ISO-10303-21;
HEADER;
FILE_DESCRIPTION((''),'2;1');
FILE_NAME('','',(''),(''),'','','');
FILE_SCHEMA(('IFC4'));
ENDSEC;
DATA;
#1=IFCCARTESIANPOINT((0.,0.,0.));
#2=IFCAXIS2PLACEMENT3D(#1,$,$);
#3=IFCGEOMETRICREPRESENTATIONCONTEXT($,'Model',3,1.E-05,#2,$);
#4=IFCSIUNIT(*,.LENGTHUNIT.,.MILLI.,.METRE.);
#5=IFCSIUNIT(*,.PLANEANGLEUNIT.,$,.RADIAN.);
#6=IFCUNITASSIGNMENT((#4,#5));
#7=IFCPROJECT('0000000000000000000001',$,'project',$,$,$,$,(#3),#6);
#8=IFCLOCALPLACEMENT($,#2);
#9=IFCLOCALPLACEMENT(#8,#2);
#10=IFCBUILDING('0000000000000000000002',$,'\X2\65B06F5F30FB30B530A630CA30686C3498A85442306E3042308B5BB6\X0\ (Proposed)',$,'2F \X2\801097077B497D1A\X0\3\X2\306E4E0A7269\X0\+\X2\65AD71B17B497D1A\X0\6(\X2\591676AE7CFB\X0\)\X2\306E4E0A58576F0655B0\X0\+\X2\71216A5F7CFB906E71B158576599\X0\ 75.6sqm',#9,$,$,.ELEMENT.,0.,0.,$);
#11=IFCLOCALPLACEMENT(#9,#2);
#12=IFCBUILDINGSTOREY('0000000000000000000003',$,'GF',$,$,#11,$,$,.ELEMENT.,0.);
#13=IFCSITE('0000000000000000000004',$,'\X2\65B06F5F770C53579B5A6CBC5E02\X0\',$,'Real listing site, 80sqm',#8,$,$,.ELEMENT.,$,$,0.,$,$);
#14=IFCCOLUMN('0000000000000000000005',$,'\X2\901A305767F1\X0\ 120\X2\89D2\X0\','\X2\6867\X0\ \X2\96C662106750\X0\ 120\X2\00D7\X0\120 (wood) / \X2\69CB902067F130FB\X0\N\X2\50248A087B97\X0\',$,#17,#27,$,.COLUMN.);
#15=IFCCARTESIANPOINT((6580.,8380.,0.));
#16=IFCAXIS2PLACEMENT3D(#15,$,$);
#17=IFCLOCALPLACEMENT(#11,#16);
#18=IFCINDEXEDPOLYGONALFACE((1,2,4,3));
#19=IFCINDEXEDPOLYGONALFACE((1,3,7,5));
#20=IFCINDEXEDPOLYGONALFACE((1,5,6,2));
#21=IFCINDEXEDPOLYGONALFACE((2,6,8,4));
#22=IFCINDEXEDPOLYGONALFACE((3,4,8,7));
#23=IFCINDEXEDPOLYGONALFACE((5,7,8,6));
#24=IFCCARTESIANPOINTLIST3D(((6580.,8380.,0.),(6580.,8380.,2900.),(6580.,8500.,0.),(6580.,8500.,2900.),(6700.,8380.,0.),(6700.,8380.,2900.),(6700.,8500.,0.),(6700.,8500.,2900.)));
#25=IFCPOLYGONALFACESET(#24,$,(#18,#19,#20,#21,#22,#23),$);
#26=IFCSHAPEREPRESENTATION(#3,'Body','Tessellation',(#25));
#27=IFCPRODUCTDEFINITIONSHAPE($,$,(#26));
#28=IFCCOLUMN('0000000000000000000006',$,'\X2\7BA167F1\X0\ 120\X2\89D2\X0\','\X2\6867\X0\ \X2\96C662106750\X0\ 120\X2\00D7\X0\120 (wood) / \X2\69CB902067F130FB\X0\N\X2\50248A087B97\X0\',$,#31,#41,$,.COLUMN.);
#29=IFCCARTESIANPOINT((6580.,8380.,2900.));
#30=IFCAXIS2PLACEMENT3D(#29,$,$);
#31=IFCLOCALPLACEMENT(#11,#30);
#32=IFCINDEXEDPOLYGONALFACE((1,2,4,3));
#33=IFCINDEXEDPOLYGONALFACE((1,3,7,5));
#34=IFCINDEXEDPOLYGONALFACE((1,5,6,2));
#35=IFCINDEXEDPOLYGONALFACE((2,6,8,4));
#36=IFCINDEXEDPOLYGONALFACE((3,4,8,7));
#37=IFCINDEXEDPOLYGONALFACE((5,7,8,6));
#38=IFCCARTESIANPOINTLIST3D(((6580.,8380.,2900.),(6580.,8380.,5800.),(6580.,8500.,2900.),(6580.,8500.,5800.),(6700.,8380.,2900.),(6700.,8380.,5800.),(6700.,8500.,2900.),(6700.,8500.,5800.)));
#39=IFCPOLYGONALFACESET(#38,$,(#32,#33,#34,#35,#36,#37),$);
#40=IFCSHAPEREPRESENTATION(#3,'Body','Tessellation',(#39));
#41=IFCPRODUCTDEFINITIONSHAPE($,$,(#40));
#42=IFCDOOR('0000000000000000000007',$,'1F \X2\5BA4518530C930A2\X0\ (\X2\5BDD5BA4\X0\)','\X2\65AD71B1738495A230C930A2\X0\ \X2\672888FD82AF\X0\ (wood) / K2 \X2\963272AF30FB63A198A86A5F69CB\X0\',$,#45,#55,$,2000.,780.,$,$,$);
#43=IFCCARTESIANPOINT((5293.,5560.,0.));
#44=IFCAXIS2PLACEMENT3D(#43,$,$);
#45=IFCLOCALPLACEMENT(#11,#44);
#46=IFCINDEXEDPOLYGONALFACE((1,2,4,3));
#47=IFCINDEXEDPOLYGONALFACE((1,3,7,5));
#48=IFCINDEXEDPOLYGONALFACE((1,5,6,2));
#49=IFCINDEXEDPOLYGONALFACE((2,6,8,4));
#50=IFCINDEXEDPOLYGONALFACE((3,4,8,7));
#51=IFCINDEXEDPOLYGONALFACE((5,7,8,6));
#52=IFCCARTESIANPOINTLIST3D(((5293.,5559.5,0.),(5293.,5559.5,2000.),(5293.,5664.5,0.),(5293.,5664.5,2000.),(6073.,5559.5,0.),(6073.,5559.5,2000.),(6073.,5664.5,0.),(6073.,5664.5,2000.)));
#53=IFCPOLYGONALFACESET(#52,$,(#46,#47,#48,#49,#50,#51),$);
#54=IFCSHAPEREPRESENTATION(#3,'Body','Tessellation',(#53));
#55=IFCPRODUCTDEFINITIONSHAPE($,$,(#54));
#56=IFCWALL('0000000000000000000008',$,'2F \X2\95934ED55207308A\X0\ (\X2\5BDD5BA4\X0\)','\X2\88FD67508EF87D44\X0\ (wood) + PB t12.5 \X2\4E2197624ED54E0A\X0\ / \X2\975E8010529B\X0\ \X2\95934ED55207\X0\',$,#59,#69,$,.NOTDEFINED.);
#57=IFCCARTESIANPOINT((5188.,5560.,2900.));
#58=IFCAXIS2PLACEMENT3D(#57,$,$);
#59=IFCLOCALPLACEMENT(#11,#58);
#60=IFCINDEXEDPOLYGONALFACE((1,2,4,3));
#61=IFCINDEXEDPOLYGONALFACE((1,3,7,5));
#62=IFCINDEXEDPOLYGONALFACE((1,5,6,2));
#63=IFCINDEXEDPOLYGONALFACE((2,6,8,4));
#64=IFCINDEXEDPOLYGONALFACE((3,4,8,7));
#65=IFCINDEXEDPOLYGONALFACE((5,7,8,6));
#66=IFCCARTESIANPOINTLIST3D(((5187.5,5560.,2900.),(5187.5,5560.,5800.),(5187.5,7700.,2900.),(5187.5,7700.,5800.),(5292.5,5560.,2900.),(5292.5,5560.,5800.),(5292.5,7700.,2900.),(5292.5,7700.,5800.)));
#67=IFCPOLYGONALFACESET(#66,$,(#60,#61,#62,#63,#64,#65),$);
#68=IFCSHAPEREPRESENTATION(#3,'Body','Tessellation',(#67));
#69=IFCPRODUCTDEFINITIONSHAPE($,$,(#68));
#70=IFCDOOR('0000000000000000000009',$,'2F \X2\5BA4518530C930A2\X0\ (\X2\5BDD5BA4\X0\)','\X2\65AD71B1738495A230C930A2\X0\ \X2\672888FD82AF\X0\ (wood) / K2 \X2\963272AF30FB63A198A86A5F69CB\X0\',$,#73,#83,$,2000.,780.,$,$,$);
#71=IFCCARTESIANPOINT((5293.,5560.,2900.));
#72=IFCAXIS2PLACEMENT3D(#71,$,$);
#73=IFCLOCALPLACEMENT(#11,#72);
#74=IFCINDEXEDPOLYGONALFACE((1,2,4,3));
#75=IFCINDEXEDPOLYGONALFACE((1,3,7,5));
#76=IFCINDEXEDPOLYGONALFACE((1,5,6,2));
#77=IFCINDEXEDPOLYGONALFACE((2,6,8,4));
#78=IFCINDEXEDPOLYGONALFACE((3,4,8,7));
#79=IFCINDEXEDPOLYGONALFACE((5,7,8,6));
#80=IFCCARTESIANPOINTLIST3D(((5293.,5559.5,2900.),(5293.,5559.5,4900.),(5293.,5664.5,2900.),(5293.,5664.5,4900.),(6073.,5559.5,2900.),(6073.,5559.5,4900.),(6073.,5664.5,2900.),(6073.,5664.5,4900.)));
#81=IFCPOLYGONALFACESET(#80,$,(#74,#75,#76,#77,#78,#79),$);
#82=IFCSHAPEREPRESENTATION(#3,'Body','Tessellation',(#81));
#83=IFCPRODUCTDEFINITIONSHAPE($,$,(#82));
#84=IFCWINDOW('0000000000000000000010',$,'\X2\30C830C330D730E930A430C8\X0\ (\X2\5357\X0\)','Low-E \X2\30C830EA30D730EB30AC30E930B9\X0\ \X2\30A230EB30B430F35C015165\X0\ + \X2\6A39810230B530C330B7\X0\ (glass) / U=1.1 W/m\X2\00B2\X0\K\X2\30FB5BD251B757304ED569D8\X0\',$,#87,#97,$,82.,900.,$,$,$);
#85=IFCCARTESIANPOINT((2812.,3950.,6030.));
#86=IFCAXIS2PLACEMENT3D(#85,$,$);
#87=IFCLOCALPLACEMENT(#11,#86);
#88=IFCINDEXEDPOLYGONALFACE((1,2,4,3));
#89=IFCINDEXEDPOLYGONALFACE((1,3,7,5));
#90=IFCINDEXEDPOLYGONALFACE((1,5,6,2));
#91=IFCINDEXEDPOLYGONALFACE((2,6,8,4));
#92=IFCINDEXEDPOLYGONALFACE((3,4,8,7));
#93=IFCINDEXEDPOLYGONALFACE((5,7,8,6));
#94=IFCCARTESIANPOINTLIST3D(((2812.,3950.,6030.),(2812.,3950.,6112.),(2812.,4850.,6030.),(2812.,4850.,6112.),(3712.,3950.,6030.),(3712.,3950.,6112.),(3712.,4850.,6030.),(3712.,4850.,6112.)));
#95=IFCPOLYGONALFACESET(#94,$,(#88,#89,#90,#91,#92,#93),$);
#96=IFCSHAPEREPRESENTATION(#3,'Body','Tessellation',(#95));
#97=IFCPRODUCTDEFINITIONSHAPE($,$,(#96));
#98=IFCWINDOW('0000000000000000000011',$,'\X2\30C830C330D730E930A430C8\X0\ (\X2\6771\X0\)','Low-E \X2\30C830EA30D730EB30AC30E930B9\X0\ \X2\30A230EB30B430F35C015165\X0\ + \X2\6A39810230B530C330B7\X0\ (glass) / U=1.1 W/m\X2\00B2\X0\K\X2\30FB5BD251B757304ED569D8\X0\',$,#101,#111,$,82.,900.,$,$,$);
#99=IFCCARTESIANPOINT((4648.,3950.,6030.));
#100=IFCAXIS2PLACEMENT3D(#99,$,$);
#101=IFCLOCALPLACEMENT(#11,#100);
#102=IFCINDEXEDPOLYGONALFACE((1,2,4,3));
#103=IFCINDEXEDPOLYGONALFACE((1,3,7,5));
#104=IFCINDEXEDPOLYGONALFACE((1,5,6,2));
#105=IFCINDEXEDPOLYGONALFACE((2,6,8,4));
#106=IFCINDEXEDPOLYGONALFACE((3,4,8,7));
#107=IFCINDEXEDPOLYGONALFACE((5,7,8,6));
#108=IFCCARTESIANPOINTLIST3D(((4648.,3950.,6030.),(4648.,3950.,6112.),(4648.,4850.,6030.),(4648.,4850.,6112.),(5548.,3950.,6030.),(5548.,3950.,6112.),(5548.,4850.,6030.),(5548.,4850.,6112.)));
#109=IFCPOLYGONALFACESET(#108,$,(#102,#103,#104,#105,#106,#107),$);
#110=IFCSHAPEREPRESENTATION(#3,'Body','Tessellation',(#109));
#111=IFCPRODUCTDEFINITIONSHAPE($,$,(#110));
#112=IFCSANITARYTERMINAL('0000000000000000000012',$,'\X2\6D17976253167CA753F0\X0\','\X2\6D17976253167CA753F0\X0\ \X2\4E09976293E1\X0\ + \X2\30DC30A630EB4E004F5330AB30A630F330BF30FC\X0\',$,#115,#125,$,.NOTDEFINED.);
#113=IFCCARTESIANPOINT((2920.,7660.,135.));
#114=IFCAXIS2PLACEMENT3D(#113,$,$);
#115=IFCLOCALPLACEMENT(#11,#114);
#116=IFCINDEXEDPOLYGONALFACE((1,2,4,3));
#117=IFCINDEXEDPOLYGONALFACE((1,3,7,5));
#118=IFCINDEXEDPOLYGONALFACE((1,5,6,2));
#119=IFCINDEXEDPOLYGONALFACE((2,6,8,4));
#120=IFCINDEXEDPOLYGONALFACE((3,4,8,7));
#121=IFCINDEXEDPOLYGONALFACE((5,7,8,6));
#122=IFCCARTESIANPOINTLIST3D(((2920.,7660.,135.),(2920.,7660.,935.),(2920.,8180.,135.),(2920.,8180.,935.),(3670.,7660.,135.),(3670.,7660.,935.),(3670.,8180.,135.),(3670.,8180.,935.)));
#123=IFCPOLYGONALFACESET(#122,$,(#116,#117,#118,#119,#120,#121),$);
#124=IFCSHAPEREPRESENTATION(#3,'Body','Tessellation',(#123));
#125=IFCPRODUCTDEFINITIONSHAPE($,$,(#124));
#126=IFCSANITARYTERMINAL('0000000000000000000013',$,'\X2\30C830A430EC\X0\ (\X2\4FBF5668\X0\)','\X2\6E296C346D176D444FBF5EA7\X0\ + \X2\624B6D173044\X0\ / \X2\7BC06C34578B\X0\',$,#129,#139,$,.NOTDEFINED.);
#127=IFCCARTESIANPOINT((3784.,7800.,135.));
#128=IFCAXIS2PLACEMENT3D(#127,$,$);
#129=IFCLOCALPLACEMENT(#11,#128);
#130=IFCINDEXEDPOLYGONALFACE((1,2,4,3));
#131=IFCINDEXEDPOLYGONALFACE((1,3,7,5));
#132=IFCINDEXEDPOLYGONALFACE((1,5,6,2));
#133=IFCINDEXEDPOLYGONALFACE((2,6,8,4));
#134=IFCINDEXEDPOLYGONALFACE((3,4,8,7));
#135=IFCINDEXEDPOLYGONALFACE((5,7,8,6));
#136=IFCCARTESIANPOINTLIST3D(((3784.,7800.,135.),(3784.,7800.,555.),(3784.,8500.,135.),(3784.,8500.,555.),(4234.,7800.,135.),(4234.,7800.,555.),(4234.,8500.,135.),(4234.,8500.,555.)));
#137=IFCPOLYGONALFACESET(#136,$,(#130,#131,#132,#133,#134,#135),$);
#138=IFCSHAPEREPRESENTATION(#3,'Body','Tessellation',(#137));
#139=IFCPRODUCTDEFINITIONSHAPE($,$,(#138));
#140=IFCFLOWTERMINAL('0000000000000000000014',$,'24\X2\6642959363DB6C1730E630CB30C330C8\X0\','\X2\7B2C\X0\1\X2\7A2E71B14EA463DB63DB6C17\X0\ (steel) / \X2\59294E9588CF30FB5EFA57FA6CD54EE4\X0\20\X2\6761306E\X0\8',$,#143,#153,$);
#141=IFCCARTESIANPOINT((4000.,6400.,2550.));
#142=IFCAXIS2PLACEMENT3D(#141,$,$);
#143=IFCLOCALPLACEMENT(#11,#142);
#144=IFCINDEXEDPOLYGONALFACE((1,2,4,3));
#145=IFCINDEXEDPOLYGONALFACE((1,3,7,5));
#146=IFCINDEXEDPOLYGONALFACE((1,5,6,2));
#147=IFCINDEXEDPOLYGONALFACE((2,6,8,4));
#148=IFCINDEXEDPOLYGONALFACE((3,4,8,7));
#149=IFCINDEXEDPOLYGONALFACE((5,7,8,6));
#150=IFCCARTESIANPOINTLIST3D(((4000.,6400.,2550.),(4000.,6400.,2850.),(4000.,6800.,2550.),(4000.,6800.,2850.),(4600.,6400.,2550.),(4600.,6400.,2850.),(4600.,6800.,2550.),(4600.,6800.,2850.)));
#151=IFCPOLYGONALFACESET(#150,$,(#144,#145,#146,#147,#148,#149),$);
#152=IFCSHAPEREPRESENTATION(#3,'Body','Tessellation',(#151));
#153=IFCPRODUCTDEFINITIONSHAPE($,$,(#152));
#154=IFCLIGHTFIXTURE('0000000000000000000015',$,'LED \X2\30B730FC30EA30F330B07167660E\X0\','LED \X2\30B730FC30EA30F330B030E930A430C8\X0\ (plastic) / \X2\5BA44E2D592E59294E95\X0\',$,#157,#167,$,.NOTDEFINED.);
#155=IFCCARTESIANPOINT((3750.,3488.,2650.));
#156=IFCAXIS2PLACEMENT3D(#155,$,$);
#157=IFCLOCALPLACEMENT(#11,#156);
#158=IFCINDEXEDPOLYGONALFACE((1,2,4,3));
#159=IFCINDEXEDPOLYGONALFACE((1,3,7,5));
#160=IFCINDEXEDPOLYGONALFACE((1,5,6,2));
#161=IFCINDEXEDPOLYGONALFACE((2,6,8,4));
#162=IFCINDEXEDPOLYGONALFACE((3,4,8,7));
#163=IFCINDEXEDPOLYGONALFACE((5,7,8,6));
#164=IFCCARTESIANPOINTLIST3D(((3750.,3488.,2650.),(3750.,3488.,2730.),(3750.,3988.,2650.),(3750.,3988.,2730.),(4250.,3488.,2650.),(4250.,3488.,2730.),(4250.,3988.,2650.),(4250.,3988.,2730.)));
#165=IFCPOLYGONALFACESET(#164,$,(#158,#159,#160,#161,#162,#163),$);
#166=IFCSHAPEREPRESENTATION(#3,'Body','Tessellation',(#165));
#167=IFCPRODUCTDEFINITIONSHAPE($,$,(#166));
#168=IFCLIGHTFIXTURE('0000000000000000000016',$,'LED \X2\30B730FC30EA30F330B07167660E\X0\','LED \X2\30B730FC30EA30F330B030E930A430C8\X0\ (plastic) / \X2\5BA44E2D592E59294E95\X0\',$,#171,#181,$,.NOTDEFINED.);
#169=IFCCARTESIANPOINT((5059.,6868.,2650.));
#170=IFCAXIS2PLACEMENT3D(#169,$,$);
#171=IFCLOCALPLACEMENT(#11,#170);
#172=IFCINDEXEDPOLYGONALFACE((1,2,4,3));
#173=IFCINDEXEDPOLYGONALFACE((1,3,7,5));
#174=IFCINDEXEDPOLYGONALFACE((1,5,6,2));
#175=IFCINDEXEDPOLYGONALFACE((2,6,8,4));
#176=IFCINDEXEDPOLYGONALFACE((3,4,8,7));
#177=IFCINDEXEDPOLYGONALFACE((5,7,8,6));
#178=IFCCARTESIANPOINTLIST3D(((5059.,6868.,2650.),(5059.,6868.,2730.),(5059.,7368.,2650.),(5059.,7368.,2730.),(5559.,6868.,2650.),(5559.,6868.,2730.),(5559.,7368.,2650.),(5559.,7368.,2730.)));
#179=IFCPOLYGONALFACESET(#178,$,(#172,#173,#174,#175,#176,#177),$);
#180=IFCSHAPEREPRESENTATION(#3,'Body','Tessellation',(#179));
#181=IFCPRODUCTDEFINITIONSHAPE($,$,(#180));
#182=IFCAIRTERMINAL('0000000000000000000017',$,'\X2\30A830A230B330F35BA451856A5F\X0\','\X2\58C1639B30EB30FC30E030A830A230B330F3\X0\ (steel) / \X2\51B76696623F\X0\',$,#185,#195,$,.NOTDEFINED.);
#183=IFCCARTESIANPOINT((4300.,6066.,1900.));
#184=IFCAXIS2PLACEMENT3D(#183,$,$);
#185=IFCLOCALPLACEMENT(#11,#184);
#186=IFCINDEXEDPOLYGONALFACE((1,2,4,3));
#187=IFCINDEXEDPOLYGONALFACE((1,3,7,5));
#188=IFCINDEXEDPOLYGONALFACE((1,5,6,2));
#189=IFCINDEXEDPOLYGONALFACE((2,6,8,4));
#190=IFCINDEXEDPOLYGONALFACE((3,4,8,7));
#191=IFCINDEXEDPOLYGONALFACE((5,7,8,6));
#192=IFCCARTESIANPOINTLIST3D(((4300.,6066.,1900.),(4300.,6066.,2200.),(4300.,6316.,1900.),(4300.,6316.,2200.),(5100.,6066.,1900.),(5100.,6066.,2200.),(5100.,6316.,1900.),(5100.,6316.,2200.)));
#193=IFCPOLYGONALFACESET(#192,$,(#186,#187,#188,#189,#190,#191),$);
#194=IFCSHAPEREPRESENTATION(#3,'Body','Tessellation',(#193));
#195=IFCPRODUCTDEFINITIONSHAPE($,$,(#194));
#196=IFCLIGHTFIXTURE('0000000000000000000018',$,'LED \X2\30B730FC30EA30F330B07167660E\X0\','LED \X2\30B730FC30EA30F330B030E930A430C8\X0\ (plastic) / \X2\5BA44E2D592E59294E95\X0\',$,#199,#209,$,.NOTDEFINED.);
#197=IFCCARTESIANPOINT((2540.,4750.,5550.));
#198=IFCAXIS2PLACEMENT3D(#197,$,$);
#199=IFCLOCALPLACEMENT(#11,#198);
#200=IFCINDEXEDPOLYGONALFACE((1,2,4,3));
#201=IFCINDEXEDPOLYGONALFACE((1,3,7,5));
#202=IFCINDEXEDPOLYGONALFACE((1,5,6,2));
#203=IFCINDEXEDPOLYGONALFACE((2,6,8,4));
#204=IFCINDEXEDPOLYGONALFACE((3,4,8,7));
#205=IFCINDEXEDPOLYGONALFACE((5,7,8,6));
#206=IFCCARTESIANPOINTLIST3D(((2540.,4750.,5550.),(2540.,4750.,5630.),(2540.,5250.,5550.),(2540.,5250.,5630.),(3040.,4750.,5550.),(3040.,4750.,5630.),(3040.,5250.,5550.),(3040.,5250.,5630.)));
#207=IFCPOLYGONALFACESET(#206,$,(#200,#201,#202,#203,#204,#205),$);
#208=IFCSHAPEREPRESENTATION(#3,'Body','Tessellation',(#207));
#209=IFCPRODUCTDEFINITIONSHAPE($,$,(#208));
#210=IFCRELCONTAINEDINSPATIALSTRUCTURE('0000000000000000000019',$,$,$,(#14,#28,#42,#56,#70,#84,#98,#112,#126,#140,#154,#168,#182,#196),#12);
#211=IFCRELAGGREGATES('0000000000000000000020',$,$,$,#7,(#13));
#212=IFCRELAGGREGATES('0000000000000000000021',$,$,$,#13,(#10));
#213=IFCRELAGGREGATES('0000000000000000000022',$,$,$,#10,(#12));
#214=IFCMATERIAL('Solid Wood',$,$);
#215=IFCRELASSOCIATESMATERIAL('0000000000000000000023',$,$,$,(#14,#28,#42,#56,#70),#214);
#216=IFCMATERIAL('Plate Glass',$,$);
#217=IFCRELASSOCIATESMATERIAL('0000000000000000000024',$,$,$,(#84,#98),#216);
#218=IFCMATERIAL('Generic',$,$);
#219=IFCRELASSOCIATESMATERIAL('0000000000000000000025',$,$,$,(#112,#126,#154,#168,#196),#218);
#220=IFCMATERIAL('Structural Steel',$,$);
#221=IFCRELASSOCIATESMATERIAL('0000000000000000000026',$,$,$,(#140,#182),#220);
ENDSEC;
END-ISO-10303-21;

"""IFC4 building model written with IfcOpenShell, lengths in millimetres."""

from ifc_helpers import new_model, si_unit, frame, frame_2d, origin, place, context, project, spatial, rectangle, extrude, material, element, save


model = new_model("IFC4")

# Units and contexts
model_context = context("Model", 3, precision=1e-05, world=origin())
ifc_project = project(units=[si_unit("LENGTHUNIT", "METRE", prefix="MILLI"), si_unit("PLANEANGLEUNIT", "RADIAN")], contexts=[model_context])

# Site, building, storey
site_placement = place(None, origin())
site = spatial("IfcSite", under=ifc_project, at=site_placement, Name="新潟県南魚沼市", ObjectType="Real listing site, 80sqm", CompositionType="ELEMENT", RefElevation=0.0)
building_placement = place(site_placement, origin())
building = spatial("IfcBuilding", under=site, at=building_placement, Name="新潟・サウナと水風呂のある家 (Proposed)", ObjectType="2F 耐震等級3の上物+断熱等級6(外皮系)の上塗漆喰+無機系遮熱塗料 75.6sqm", CompositionType="ELEMENT", ElevationOfRefHeight=0.0, ElevationOfTerrain=0.0)
storey_placement = place(building_placement, origin())
storey = spatial("IfcBuildingStorey", under=building, at=storey_placement, Name="GF", CompositionType="ELEMENT", Elevation=0.0)

# Columns
ifc_material_1 = material(Name="Solid Wood")
column_1_placement = place(storey_placement, frame((6580.0, 8380.0, 0.0)))
element("IfcColumn", 1, at=column_1_placement, inside=storey, material=ifc_material_1, Name="通し柱 120角", Description="桧 集成材 120×120 (wood) / 構造柱・N値計算", PredefinedType="COLUMN", context=model_context, shape_type="SweptSolid", body=[
    extrude(rectangle(XDim=120.0, YDim=120.0, at=frame_2d((60.0, 60.0))), frame((6580.0, 8380.0, 0.0)), (0.0, 0.0, 1.0), 2900.0),
])
column_2_placement = place(storey_placement, frame((6580.0, 8380.0, 2900.0)))
element("IfcColumn", 2, at=column_2_placement, inside=storey, material=ifc_material_1, Name="管柱 120角", Description="桧 集成材 120×120 (wood) / 構造柱・N値計算", PredefinedType="COLUMN", context=model_context, shape_type="SweptSolid", body=[
    extrude(rectangle(XDim=120.0, YDim=120.0, at=frame_2d((60.0, 60.0))), frame((6580.0, 8380.0, 2900.0)), (0.0, 0.0, 1.0), 2900.0),
])

# Door
door_1_placement = place(storey_placement, frame((5293.0, 5560.0, 0.0)))
element("IfcDoor", 3, at=door_1_placement, inside=storey, material=ifc_material_1, Name="1F 室内ドア (寝室)", Description="断熱玄関ドア 木製芯 (wood) / K2 防犯・採風機構", OverallHeight=2000.0, OverallWidth=780.0, context=model_context, shape_type="SweptSolid", body=[
    extrude(rectangle(XDim=780.0, YDim=105.0, at=frame_2d((390.0, 52.0))), frame((5293.0, 5560.0, 0.0)), (0.0, 0.0, 1.0), 2000.0),
])

# Wall
wall_1_placement = place(storey_placement, frame((5188.0, 5560.0, 2900.0)))
element("IfcWall", 4, at=wall_1_placement, inside=storey, material=ifc_material_1, Name="2F 間仕切り (寝室)", Description="製材軸組 (wood) + PB t12.5 両面仕上 / 非耐力 間仕切", PredefinedType="NOTDEFINED", context=model_context, shape_type="SweptSolid", body=[
    extrude(rectangle(XDim=105.0, YDim=2140.0, at=frame_2d((52.0, 1070.0))), frame((5188.0, 5560.0, 2900.0)), (0.0, 0.0, 1.0), 2900.0),
])

# Door
door_2_placement = place(storey_placement, frame((5293.0, 5560.0, 2900.0)))
element("IfcDoor", 5, at=door_2_placement, inside=storey, material=ifc_material_1, Name="2F 室内ドア (寝室)", Description="断熱玄関ドア 木製芯 (wood) / K2 防犯・採風機構", OverallHeight=2000.0, OverallWidth=780.0, context=model_context, shape_type="SweptSolid", body=[
    extrude(rectangle(XDim=780.0, YDim=105.0, at=frame_2d((390.0, 52.0))), frame((5293.0, 5560.0, 2900.0)), (0.0, 0.0, 1.0), 2000.0),
])

# Windows
ifc_material_2 = material(Name="Plate Glass")
window_1_placement = place(storey_placement, frame((2812.0, 3950.0, 6030.0)))
element("IfcWindow", 6, at=window_1_placement, inside=storey, material=ifc_material_2, Name="トップライト (南)", Description="Low-E トリプルガラス アルゴン封入 + 樹脂サッシ (glass) / U=1.1 W/m²K・寒冷地仕様", OverallHeight=82.0, OverallWidth=900.0, context=model_context, shape_type="SweptSolid", body=[
    extrude(rectangle(XDim=900.0, YDim=900.0, at=frame_2d((450.0, 450.0))), frame((2812.0, 3950.0, 6030.0)), (0.0, 0.0, 1.0), 82.0),
])
window_2_placement = place(storey_placement, frame((4648.0, 3950.0, 6030.0)))
element("IfcWindow", 7, at=window_2_placement, inside=storey, material=ifc_material_2, Name="トップライト (東)", Description="Low-E トリプルガラス アルゴン封入 + 樹脂サッシ (glass) / U=1.1 W/m²K・寒冷地仕様", OverallHeight=82.0, OverallWidth=900.0, context=model_context, shape_type="SweptSolid", body=[
    extrude(rectangle(XDim=900.0, YDim=900.0, at=frame_2d((450.0, 450.0))), frame((4648.0, 3950.0, 6030.0)), (0.0, 0.0, 1.0), 82.0),
])

# Sanitary terminals
ifc_material_3 = material(Name="Generic")
sanitary_terminal_1_placement = place(storey_placement, frame((2920.0, 7660.0, 135.0)))
element("IfcSanitaryTerminal", 8, at=sanitary_terminal_1_placement, inside=storey, material=ifc_material_3, Name="洗面化粧台", Description="洗面化粧台 三面鏡 + ボウル一体カウンター", PredefinedType="NOTDEFINED", context=model_context, shape_type="SweptSolid", body=[
    extrude(rectangle(XDim=750.0, YDim=520.0, at=frame_2d((375.0, 260.0))), frame((2920.0, 7660.0, 135.0)), (0.0, 0.0, 1.0), 800.0),
])
sanitary_terminal_2_placement = place(storey_placement, frame((3784.0, 7800.0, 135.0)))
element("IfcSanitaryTerminal", 9, at=sanitary_terminal_2_placement, inside=storey, material=ifc_material_3, Name="トイレ (便器)", Description="温水洗浄便座 + 手洗い / 節水型", PredefinedType="NOTDEFINED", context=model_context, shape_type="SweptSolid", body=[
    extrude(rectangle(XDim=450.0, YDim=700.0, at=frame_2d((225.0, 350.0))), frame((3784.0, 7800.0, 135.0)), (0.0, 0.0, 1.0), 420.0),
])

# Flow terminal
ifc_material_4 = material(Name="Structural Steel")
flow_terminal_placement = place(storey_placement, frame((4000.0, 6400.0, 2550.0)))
element("IfcFlowTerminal", 10, at=flow_terminal_placement, inside=storey, material=ifc_material_4, Name="24時間換気ユニット", Description="第1種熱交換換気 (steel) / 天井裏・建基法令20条の8", context=model_context, shape_type="SweptSolid", body=[
    extrude(rectangle(XDim=600.0, YDim=400.0, at=frame_2d((300.0, 200.0))), frame((4000.0, 6400.0, 2550.0)), (0.0, 0.0, 1.0), 300.0),
])

# Light fixtures
light_fixture_1_placement = place(storey_placement, frame((3750.0, 3488.0, 2650.0)))
element("IfcLightFixture", 11, at=light_fixture_1_placement, inside=storey, material=ifc_material_3, Name="LED シーリング照明", Description="LED シーリングライト (plastic) / 室中央天井", PredefinedType="NOTDEFINED", context=model_context, shape_type="SweptSolid", body=[
    extrude(rectangle(XDim=500.0, YDim=500.0, at=frame_2d((250.0, 250.0))), frame((3750.0, 3488.0, 2650.0)), (0.0, 0.0, 1.0), 80.0),
])
light_fixture_2_placement = place(storey_placement, frame((5059.0, 6868.0, 2650.0)))
element("IfcLightFixture", 12, at=light_fixture_2_placement, inside=storey, material=ifc_material_3, Name="LED シーリング照明", Description="LED シーリングライト (plastic) / 室中央天井", PredefinedType="NOTDEFINED", context=model_context, shape_type="SweptSolid", body=[
    extrude(rectangle(XDim=500.0, YDim=500.0, at=frame_2d((250.0, 250.0))), frame((5059.0, 6868.0, 2650.0)), (0.0, 0.0, 1.0), 80.0),
])

# Air terminal
air_terminal_placement = place(storey_placement, frame((4300.0, 6066.0, 1900.0)))
element("IfcAirTerminal", 13, at=air_terminal_placement, inside=storey, material=ifc_material_4, Name="エアコン室内機", Description="壁掛ルームエアコン (steel) / 冷暖房", PredefinedType="NOTDEFINED", context=model_context, shape_type="SweptSolid", body=[
    extrude(rectangle(XDim=800.0, YDim=250.0, at=frame_2d((400.0, 125.0))), frame((4300.0, 6066.0, 1900.0)), (0.0, 0.0, 1.0), 300.0),
])

# Light fixture
light_fixture_3_placement = place(storey_placement, frame((2540.0, 4750.0, 5550.0)))
element("IfcLightFixture", 14, at=light_fixture_3_placement, inside=storey, material=ifc_material_3, Name="LED シーリング照明", Description="LED シーリングライト (plastic) / 室中央天井", PredefinedType="NOTDEFINED", context=model_context, shape_type="SweptSolid", body=[
    extrude(rectangle(XDim=500.0, YDim=500.0, at=frame_2d((250.0, 250.0))), frame((2540.0, 4750.0, 5550.0)), (0.0, 0.0, 1.0), 80.0),
])

save(model, "model.ifc")
